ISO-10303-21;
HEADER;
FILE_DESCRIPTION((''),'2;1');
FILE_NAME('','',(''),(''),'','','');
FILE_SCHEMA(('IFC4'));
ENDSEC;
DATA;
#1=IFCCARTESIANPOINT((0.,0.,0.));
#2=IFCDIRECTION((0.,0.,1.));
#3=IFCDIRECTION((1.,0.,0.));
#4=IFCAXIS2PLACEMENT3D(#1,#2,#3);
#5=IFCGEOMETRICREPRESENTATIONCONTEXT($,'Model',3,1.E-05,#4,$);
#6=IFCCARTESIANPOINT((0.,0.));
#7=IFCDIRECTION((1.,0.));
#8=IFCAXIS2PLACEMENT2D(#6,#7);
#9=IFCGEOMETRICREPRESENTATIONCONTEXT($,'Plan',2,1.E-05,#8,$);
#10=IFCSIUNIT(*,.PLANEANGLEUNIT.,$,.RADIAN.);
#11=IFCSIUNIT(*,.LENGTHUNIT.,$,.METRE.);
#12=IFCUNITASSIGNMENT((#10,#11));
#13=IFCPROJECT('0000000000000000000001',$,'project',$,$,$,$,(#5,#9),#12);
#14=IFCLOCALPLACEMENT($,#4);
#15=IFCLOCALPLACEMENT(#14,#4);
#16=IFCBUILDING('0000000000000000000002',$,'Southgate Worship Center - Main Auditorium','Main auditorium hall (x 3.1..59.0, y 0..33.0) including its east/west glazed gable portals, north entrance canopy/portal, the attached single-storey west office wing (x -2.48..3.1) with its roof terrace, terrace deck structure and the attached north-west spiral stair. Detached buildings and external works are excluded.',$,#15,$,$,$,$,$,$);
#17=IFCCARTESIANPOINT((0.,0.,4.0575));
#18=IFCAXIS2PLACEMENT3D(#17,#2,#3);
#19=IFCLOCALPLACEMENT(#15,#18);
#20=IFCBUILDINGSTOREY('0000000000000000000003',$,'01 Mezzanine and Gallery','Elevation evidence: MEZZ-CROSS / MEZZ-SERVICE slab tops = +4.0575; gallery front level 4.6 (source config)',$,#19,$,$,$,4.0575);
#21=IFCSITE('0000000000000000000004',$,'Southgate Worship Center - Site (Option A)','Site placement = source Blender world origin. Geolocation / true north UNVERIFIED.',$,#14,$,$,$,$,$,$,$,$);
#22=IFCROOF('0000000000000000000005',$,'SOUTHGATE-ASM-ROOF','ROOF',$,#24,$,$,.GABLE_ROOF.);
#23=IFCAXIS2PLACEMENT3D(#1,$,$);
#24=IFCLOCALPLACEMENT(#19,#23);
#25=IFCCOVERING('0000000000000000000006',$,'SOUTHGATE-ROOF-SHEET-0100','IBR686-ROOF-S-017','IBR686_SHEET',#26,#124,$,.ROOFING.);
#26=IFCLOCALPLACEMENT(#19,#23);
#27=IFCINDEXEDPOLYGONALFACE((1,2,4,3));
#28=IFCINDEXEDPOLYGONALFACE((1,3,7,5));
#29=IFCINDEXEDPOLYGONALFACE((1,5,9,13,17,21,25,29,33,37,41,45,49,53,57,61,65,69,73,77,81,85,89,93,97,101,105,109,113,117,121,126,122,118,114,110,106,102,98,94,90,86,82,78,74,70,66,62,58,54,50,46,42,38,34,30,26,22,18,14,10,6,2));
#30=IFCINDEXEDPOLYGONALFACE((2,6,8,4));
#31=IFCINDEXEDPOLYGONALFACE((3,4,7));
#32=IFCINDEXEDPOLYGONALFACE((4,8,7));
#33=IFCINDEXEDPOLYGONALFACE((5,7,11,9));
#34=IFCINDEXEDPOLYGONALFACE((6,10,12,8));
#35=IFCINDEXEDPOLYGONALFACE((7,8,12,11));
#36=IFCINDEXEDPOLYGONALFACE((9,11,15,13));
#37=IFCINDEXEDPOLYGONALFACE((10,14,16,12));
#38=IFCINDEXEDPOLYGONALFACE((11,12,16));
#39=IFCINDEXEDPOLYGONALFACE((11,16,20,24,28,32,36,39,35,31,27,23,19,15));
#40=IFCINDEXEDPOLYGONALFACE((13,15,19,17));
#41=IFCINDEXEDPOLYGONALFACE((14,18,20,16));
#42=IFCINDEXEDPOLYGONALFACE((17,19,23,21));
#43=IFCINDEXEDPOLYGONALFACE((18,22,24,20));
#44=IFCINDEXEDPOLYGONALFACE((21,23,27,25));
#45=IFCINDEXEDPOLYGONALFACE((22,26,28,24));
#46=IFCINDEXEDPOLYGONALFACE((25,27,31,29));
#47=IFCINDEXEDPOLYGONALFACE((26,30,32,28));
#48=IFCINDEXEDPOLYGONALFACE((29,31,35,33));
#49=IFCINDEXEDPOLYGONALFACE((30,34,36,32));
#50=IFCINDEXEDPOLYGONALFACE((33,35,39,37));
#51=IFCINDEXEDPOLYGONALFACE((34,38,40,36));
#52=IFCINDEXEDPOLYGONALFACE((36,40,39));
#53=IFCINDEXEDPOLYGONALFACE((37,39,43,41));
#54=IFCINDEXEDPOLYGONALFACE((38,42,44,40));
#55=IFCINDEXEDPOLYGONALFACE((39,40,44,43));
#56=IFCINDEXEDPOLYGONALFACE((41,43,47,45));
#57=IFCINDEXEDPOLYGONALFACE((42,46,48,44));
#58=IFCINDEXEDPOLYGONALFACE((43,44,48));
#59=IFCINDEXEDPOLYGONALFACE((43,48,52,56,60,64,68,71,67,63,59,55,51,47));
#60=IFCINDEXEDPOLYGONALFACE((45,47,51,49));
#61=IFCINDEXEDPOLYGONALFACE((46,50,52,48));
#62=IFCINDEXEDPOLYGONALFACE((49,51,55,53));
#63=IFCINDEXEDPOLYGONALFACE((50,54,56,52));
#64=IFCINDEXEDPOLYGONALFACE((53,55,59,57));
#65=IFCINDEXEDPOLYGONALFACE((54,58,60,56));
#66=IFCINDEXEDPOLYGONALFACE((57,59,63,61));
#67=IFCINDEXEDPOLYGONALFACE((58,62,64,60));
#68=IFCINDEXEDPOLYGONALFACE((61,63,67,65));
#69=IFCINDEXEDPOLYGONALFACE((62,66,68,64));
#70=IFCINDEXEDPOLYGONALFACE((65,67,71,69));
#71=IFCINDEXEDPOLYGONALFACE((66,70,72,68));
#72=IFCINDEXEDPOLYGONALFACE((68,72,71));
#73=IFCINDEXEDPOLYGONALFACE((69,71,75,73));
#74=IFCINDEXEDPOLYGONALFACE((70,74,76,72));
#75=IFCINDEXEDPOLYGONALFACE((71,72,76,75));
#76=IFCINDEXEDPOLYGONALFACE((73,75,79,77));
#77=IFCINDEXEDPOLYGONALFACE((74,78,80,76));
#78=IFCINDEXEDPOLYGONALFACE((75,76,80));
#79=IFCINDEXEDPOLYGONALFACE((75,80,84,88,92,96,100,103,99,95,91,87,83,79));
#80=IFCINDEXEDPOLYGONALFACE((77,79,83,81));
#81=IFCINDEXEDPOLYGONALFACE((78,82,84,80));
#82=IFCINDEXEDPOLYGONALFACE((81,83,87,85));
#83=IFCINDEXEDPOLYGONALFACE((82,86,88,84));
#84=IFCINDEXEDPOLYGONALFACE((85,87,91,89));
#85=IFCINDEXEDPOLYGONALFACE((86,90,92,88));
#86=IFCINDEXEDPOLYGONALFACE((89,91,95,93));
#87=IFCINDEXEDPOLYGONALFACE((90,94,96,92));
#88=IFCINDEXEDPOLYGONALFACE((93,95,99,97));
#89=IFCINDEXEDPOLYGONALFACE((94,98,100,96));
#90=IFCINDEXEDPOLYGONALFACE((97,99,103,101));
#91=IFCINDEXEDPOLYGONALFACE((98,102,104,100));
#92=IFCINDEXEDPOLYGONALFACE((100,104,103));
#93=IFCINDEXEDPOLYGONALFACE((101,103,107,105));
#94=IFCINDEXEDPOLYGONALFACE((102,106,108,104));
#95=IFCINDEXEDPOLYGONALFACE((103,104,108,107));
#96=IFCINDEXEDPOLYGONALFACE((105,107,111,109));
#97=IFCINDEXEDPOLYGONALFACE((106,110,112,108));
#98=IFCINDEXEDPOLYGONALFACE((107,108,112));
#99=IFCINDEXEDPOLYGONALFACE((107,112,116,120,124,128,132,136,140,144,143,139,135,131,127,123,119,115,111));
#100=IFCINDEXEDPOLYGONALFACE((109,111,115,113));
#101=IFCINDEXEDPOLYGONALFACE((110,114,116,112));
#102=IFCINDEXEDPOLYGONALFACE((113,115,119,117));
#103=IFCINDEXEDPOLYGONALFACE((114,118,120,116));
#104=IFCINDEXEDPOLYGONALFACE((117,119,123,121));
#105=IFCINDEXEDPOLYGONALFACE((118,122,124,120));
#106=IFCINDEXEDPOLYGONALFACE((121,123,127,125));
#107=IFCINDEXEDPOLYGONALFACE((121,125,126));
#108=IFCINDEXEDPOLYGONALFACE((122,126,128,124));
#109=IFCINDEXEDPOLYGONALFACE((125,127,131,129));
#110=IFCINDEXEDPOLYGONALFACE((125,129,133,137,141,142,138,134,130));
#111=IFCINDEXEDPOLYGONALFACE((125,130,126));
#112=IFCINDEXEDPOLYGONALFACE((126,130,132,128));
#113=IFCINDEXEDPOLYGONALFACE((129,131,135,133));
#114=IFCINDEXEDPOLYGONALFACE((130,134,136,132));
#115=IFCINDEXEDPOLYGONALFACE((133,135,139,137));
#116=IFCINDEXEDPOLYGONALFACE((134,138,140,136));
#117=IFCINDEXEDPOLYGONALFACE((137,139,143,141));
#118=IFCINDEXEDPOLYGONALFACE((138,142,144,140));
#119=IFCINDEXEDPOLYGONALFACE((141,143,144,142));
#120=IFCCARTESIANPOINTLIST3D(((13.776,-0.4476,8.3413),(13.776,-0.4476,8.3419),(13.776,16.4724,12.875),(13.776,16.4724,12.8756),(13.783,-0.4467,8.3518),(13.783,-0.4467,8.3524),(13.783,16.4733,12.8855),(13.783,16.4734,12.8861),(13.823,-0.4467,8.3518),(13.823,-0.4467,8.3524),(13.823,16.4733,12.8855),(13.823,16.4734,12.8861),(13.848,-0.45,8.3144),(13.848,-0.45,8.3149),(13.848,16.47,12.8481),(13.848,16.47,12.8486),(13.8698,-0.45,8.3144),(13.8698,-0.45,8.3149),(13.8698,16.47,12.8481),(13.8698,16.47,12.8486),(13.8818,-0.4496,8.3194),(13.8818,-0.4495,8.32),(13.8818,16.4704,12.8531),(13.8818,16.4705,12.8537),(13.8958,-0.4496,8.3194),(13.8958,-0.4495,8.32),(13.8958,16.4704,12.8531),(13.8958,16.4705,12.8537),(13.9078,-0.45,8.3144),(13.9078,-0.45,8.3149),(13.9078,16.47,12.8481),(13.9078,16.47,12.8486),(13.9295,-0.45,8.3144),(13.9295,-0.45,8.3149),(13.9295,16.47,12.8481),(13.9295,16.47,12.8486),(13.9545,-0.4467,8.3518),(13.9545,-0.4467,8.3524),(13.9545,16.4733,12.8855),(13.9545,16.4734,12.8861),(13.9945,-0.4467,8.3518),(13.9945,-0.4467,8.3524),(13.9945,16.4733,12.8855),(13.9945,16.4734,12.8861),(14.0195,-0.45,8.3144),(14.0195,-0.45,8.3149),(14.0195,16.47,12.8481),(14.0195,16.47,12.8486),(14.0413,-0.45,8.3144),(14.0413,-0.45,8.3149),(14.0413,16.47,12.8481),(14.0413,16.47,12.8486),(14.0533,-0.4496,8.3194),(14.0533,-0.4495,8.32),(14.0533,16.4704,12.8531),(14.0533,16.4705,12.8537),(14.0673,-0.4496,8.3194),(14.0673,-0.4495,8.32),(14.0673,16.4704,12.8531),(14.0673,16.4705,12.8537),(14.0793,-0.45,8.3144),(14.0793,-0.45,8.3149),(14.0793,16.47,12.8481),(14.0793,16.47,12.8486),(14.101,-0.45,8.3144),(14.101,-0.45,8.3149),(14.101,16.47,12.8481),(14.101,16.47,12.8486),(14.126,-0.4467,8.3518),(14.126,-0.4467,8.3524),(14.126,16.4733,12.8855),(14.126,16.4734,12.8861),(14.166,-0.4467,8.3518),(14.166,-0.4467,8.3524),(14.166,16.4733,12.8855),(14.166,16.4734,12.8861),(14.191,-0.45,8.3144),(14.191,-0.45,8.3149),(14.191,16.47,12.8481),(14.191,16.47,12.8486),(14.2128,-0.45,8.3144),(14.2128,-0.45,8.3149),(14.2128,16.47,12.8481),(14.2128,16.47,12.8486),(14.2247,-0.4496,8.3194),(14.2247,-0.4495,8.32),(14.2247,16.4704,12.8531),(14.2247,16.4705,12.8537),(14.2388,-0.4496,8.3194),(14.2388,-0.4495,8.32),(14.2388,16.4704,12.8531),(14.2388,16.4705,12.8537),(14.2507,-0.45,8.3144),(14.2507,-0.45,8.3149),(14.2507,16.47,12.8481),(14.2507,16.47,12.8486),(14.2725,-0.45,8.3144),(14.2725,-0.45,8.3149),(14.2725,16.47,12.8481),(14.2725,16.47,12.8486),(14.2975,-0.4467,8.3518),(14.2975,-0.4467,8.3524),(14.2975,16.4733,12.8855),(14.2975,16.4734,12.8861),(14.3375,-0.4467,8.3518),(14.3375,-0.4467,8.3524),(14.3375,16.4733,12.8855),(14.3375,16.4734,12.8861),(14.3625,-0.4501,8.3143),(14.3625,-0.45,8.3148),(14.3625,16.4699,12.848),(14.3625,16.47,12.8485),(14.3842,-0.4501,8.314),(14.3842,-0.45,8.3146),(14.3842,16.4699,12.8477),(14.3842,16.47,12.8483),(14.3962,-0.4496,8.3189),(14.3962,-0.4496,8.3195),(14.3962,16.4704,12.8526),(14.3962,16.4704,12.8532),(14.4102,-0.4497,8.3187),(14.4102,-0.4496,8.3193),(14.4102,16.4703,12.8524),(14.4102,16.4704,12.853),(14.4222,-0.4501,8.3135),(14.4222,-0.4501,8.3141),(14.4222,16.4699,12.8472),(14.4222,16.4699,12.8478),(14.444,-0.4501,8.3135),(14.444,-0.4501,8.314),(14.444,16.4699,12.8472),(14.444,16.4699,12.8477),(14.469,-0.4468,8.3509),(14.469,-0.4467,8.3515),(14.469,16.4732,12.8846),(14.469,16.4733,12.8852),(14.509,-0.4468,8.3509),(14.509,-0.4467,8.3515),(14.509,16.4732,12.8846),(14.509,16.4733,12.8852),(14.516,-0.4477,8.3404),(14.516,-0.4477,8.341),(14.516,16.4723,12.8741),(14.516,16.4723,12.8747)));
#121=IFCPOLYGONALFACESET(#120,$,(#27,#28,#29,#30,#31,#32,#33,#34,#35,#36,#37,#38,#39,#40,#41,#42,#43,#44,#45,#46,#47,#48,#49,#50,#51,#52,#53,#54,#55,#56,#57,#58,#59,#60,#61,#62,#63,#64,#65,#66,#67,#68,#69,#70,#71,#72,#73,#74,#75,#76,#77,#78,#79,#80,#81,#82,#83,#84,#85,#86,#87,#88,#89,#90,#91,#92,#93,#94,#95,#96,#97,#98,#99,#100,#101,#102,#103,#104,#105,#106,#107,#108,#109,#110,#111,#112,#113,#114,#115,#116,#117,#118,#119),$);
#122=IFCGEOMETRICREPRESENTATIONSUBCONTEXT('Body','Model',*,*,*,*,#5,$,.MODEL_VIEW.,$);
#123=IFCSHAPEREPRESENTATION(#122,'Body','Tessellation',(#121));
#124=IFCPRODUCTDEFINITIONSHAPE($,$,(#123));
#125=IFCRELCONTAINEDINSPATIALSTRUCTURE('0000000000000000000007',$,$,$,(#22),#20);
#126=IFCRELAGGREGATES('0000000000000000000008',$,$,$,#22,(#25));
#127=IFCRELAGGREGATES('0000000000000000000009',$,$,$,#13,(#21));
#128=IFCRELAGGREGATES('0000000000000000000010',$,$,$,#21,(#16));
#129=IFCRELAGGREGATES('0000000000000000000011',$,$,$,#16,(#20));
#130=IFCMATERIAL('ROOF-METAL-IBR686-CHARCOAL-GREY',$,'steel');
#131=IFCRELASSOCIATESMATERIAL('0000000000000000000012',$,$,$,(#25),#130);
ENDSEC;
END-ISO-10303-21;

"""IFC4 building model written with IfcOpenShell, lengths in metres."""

from ifc_helpers import new_model, si_unit, frame, origin_with_axes, origin_2d_with_axis, place, context, subcontext, project, spatial, indexed_curve, outline, extrude, clip, halfspace, material, element, aggregate, save


model = new_model("IFC4")

# Units and contexts
model_context = context("Model", 3, precision=1e-05, world=origin_with_axes())
plan_context = context("Plan", 2, precision=1e-05, world=origin_2d_with_axis())
body_context = subcontext(model_context, "Body", "Model", "MODEL_VIEW")
ifc_project = project(units=[si_unit("PLANEANGLEUNIT", "RADIAN"), si_unit("LENGTHUNIT", "METRE")], contexts=[model_context, plan_context])

# Site, building, storey
site_placement = place(None, origin_with_axes())
site = spatial("IfcSite", under=ifc_project, at=site_placement, Name="Southgate Worship Center - Site (Option A)", Description="Site placement = source Blender world origin. Geolocation / true north UNVERIFIED.")
building_placement = place(site_placement, origin_with_axes())
building = spatial("IfcBuilding", under=site, at=building_placement, Name="Southgate Worship Center - Main Auditorium", Description="Main auditorium hall (x 3.1..59.0, y 0..33.0) including its east/west glazed gable portals, north entrance canopy/portal, the attached single-storey west office wing (x -2.48..3.1) with its roof terrace, terrace deck structure and the attached north-west spiral stair. Detached buildings and external works are excluded.")
storey_placement = place(building_placement, frame((0.0, 0.0, 4.0575), z_axis=(0.0, 0.0, 1.0), x_axis=(1.0, 0.0, 0.0)))
storey = spatial("IfcBuildingStorey", under=building, at=storey_placement, Name="01 Mezzanine and Gallery", Description="Elevation evidence: MEZZ-CROSS / MEZZ-SERVICE slab tops = +4.0575; gallery front level 4.6 (source config)", Elevation=4.0575)

# Roof, covering
roof_placement = place(storey_placement, origin_with_axes())
roof = element("IfcRoof", 1, at=roof_placement, inside=storey, Name="SOUTHGATE-ASM-ROOF", Description="ROOF", PredefinedType="GABLE_ROOF")
ifc_material_1 = material(Name="ROOF-METAL-IBR686-CHARCOAL-GREY", Category="steel")
covering_1_placement = place(roof_placement, frame((13.776, -0.4501, 8.3135), z_axis=(0.0, 0.0, 1.0), x_axis=(1.0, 0.0, 0.0)))
covering_1 = element("IfcCovering", 2, at=covering_1_placement, material=ifc_material_1, Name="SOUTHGATE-ROOF-SHEET-0100", Description="IBR686-ROOF-S-017", ObjectType="IBR686_SHEET", PredefinedType="ROOFING", context=body_context, shape_type="Clipping", body=[
    clip(clip(extrude(outline(indexed_curve([(0.0, 0.0), (0.025, 0.0353), (0.065, 0.0353), (0.072, 0.0254), (0.072, 0.0259), (0.065, 0.0358), (0.025, 0.0358), (0.0, 0.0005), (-0.0218, 0.0005), (-0.0338, 0.0053), (-0.0478, 0.0053), (-0.0598, 0.0005), (-0.0815, 0.0005), (-0.1065, 0.0358), (-0.1465, 0.0358), (-0.1715, 0.0005), (-0.1933, 0.0005), (-0.2053, 0.0053), (-0.2193, 0.0053), (-0.2313, 0.0005), (-0.253, 0.0005), (-0.278, 0.0358), (-0.318, 0.0358), (-0.343, 0.0005), (-0.3648, 0.0005), (-0.3767, 0.0053), (-0.3908, 0.0053), (-0.4028, 0.0005), (-0.4245, 0.0005), (-0.4495, 0.0358), (-0.4895, 0.0358), (-0.5145, 0.0004), (-0.5363, 0.0002), (-0.5483, 0.0048), (-0.5623, 0.0046), (-0.5743, -0.0003), (-0.596, -0.0004), (-0.621, 0.0349), (-0.661, 0.0349), (-0.668, 0.0251), (-0.668, 0.0246), (-0.661, 0.0344), (-0.621, 0.0344), (-0.596, -0.0009), (-0.5743, -0.0008), (-0.5623, 0.0041), (-0.5483, 0.0043), (-0.5363, -0.0003), (-0.5145, -0.0001), (-0.4895, 0.0353), (-0.4495, 0.0353), (-0.4245, 0.0), (-0.4028, 0.0), (-0.3908, 0.0048), (-0.3767, 0.0048), (-0.3648, 0.0), (-0.343, 0.0), (-0.318, 0.0353), (-0.278, 0.0353), (-0.253, 0.0), (-0.2313, 0.0), (-0.2193, 0.0048), (-0.2053, 0.0048), (-0.1933, 0.0), (-0.1715, 0.0), (-0.1465, 0.0353), (-0.1065, 0.0353), (-0.0815, 0.0), (-0.0598, 0.0), (-0.0478, 0.0048), (-0.0338, 0.0048), (-0.0218, 0.0), (0.0, 0.0)], self_intersect=False)), frame((0.072, -0.0003, 0.0008), z_axis=(0.0, 0.965926, 0.258819), x_axis=(-1.0, 0.0, 0.0)), (0.0, 0.0, 1.0), 17.5303), halfspace(frame((0.37, 0.0012, 0.014), z_axis=(0.0, -0.996022, 0.089113), x_axis=(1.0, 0.0, 0.0)), False)), halfspace(frame((0.37, 16.9212, 4.5477), z_axis=(0.0, 0.996021, -0.089119), x_axis=(-1.0, 0.0, 0.0)), False)),
])
aggregate(roof, [covering_1])

save(model, "model.ifc")
